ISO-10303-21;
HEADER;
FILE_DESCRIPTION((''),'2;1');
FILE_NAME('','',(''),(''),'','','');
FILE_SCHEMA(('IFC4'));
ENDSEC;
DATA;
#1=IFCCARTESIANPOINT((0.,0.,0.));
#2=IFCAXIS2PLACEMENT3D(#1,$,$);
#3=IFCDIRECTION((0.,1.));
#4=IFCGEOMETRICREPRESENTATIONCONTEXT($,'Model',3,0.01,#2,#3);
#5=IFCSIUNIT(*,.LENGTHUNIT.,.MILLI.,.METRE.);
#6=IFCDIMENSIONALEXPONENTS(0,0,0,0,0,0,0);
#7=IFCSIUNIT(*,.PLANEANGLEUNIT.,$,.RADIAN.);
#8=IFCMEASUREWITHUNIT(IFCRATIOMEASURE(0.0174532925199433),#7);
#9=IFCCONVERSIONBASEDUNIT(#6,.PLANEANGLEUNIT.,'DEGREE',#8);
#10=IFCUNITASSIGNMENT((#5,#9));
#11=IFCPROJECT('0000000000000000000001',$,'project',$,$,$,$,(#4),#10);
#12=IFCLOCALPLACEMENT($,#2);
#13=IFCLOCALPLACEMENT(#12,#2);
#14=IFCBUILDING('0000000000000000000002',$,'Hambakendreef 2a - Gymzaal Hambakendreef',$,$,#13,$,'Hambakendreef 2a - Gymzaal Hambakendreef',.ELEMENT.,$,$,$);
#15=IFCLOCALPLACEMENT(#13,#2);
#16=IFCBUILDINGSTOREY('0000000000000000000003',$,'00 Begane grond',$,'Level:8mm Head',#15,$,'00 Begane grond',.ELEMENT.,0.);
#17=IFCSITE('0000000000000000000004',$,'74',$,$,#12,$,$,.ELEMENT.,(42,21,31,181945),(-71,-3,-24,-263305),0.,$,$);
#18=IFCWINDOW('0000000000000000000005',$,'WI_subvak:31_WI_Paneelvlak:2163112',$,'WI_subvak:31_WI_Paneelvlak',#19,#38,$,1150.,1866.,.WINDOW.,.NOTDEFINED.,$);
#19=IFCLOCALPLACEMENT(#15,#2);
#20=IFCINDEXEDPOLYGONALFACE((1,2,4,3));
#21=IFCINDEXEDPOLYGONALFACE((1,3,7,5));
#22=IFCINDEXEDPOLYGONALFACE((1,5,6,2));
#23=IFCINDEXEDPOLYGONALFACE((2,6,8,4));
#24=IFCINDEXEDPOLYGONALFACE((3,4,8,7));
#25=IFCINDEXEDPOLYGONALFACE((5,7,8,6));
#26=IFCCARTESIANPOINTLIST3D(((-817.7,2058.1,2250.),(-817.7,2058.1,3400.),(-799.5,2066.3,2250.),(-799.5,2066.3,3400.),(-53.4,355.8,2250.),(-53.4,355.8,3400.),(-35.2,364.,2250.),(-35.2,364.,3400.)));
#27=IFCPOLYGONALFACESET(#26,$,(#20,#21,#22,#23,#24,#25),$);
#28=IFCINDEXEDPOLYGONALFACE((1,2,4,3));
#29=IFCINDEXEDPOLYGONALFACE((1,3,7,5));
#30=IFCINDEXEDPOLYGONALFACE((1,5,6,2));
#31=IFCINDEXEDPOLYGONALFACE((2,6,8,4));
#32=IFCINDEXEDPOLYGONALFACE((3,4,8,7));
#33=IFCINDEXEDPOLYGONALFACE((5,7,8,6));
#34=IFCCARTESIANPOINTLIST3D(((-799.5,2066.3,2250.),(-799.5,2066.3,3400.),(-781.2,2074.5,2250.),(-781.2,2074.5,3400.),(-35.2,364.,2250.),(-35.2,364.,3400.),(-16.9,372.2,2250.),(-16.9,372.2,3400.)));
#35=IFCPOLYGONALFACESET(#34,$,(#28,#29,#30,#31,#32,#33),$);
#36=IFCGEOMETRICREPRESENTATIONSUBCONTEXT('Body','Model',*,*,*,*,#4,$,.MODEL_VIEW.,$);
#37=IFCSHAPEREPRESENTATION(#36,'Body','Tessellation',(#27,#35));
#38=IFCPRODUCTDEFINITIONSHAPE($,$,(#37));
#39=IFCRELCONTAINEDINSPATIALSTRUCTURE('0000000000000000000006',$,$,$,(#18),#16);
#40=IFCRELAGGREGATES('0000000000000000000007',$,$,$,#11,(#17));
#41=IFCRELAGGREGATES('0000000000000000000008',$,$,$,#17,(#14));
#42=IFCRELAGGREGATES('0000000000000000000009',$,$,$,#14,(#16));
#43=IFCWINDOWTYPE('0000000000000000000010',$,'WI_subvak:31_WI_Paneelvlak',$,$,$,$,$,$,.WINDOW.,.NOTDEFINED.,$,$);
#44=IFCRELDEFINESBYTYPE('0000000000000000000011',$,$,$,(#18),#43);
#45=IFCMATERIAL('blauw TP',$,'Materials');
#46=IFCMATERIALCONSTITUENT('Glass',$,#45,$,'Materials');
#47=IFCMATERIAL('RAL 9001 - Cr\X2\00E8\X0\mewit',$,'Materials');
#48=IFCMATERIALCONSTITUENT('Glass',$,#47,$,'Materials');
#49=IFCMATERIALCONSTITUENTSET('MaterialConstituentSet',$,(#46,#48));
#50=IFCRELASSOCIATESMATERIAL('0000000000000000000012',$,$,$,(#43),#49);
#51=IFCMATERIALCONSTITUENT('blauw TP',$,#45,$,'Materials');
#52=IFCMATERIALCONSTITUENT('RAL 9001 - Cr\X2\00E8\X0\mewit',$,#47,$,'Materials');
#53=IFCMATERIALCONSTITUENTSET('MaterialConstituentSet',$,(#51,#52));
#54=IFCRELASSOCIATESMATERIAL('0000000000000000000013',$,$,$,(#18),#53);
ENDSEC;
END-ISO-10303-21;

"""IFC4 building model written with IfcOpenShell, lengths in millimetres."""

from ifc_helpers import new_model, entity, si_unit, converted_unit, direction, frame, origin, place, context, subcontext, project, spatial, indexed_curve, outline, extrude, source, transform, mapped, material, constituent, constituent_set, type_object, type_shapes, element, save


model = new_model("IFC4")

# Units and contexts
model_context = context("Model", 3, precision=0.01, world=origin(), true_north=direction((0.0, 1.0)))
body_context = subcontext(model_context, "Body", "Model", "MODEL_VIEW")
ifc_project = project(units=[si_unit("LENGTHUNIT", "METRE", prefix="MILLI"), converted_unit("PLANEANGLEUNIT", "DEGREE", entity("IfcRatioMeasure", 0.0174532925199433), si_unit("PLANEANGLEUNIT", "RADIAN"), dimensions=[0, 0, 0, 0, 0, 0, 0])], contexts=[model_context])

# Site, building, storey
site_placement = place(None, origin())
site = spatial("IfcSite", under=ifc_project, at=site_placement, Name="74", CompositionType="ELEMENT", RefLatitude=(42, 21, 31, 181945), RefLongitude=(-71, -3, -24, -263305), RefElevation=0.0)
building_placement = place(site_placement, origin())
building = spatial("IfcBuilding", under=site, at=building_placement, Name="Hambakendreef 2a - Gymzaal Hambakendreef", LongName="Hambakendreef 2a - Gymzaal Hambakendreef", CompositionType="ELEMENT")
storey_placement = place(building_placement, origin())
storey = spatial("IfcBuildingStorey", under=building, at=storey_placement, Name="00 Begane grond", ObjectType="Level:8mm Head", LongName="00 Begane grond", CompositionType="ELEMENT", Elevation=0.0)

# Window
ifc_material_1 = material(Name="blauw TP", Category="Materials")
ifc_material_2 = material(Name="RAL 9001 - Crèmewit", Category="Materials")
ifc_constituent_1 = constituent(ifc_material_1, Name="blauw TP", Category="Materials")
ifc_constituent_2 = constituent(ifc_material_2, Name="RAL 9001 - Crèmewit", Category="Materials")
ifc_constituent_set_1 = constituent_set(constituents=[ifc_constituent_1, ifc_constituent_2], Name="MaterialConstituentSet")
ifc_constituent_3 = constituent(ifc_material_1, Name="Glass", Category="Materials")
ifc_constituent_4 = constituent(ifc_material_2, Name="Glass", Category="Materials")
ifc_constituent_set_2 = constituent_set(constituents=[ifc_constituent_3, ifc_constituent_4], Name="MaterialConstituentSet")
window_type_1 = type_object("IfcWindowType", Name="WI_subvak:31_WI_Paneelvlak", PartitioningType="NOTDEFINED", PredefinedType="WINDOW", material=ifc_constituent_set_2)
shared_shape_1 = source(origin(), body_context, "Body", "SweptSolid", [
    extrude(outline(indexed_curve([(-933.0, -10.0), (933.0, -10.0), (933.0, 10.0), (-933.0, 10.0), (-933.0, -10.0)], self_intersect=False)), frame((0.0, -10.0, 0.0)), (0.0, 0.0, 1.0), 1150.0),
    extrude(outline(indexed_curve([(-933.0, -10.0), (933.0, -10.0), (933.0, 10.0), (-933.0, 10.0), (-933.0, -10.0)], self_intersect=False)), frame((0.0, 10.0, 0.0)), (0.0, 0.0, 1.0), 1150.0),
])
type_shapes(window_type_1, [shared_shape_1])
window_1_placement = place(storey_placement, frame((-417.3, 1215.2, 2250.0), z_axis=(0.0, 0.0, 1.0), x_axis=(0.40959, -0.91227, 0.0)))
element("IfcWindow", 1, at=window_1_placement, inside=storey, type_object=window_type_1, material=ifc_constituent_set_1, Name="WI_subvak:31_WI_Paneelvlak:2163112", ObjectType="WI_subvak:31_WI_Paneelvlak", OverallHeight=1150.0, OverallWidth=1866.0, PartitioningType="NOTDEFINED", PredefinedType="WINDOW", context=body_context, shape_type="MappedRepresentation", body=[
    mapped(shared_shape_1, transform((0.0, 0.0, 0.0), scale=1.0)),
])

save(model, "model.ifc")
